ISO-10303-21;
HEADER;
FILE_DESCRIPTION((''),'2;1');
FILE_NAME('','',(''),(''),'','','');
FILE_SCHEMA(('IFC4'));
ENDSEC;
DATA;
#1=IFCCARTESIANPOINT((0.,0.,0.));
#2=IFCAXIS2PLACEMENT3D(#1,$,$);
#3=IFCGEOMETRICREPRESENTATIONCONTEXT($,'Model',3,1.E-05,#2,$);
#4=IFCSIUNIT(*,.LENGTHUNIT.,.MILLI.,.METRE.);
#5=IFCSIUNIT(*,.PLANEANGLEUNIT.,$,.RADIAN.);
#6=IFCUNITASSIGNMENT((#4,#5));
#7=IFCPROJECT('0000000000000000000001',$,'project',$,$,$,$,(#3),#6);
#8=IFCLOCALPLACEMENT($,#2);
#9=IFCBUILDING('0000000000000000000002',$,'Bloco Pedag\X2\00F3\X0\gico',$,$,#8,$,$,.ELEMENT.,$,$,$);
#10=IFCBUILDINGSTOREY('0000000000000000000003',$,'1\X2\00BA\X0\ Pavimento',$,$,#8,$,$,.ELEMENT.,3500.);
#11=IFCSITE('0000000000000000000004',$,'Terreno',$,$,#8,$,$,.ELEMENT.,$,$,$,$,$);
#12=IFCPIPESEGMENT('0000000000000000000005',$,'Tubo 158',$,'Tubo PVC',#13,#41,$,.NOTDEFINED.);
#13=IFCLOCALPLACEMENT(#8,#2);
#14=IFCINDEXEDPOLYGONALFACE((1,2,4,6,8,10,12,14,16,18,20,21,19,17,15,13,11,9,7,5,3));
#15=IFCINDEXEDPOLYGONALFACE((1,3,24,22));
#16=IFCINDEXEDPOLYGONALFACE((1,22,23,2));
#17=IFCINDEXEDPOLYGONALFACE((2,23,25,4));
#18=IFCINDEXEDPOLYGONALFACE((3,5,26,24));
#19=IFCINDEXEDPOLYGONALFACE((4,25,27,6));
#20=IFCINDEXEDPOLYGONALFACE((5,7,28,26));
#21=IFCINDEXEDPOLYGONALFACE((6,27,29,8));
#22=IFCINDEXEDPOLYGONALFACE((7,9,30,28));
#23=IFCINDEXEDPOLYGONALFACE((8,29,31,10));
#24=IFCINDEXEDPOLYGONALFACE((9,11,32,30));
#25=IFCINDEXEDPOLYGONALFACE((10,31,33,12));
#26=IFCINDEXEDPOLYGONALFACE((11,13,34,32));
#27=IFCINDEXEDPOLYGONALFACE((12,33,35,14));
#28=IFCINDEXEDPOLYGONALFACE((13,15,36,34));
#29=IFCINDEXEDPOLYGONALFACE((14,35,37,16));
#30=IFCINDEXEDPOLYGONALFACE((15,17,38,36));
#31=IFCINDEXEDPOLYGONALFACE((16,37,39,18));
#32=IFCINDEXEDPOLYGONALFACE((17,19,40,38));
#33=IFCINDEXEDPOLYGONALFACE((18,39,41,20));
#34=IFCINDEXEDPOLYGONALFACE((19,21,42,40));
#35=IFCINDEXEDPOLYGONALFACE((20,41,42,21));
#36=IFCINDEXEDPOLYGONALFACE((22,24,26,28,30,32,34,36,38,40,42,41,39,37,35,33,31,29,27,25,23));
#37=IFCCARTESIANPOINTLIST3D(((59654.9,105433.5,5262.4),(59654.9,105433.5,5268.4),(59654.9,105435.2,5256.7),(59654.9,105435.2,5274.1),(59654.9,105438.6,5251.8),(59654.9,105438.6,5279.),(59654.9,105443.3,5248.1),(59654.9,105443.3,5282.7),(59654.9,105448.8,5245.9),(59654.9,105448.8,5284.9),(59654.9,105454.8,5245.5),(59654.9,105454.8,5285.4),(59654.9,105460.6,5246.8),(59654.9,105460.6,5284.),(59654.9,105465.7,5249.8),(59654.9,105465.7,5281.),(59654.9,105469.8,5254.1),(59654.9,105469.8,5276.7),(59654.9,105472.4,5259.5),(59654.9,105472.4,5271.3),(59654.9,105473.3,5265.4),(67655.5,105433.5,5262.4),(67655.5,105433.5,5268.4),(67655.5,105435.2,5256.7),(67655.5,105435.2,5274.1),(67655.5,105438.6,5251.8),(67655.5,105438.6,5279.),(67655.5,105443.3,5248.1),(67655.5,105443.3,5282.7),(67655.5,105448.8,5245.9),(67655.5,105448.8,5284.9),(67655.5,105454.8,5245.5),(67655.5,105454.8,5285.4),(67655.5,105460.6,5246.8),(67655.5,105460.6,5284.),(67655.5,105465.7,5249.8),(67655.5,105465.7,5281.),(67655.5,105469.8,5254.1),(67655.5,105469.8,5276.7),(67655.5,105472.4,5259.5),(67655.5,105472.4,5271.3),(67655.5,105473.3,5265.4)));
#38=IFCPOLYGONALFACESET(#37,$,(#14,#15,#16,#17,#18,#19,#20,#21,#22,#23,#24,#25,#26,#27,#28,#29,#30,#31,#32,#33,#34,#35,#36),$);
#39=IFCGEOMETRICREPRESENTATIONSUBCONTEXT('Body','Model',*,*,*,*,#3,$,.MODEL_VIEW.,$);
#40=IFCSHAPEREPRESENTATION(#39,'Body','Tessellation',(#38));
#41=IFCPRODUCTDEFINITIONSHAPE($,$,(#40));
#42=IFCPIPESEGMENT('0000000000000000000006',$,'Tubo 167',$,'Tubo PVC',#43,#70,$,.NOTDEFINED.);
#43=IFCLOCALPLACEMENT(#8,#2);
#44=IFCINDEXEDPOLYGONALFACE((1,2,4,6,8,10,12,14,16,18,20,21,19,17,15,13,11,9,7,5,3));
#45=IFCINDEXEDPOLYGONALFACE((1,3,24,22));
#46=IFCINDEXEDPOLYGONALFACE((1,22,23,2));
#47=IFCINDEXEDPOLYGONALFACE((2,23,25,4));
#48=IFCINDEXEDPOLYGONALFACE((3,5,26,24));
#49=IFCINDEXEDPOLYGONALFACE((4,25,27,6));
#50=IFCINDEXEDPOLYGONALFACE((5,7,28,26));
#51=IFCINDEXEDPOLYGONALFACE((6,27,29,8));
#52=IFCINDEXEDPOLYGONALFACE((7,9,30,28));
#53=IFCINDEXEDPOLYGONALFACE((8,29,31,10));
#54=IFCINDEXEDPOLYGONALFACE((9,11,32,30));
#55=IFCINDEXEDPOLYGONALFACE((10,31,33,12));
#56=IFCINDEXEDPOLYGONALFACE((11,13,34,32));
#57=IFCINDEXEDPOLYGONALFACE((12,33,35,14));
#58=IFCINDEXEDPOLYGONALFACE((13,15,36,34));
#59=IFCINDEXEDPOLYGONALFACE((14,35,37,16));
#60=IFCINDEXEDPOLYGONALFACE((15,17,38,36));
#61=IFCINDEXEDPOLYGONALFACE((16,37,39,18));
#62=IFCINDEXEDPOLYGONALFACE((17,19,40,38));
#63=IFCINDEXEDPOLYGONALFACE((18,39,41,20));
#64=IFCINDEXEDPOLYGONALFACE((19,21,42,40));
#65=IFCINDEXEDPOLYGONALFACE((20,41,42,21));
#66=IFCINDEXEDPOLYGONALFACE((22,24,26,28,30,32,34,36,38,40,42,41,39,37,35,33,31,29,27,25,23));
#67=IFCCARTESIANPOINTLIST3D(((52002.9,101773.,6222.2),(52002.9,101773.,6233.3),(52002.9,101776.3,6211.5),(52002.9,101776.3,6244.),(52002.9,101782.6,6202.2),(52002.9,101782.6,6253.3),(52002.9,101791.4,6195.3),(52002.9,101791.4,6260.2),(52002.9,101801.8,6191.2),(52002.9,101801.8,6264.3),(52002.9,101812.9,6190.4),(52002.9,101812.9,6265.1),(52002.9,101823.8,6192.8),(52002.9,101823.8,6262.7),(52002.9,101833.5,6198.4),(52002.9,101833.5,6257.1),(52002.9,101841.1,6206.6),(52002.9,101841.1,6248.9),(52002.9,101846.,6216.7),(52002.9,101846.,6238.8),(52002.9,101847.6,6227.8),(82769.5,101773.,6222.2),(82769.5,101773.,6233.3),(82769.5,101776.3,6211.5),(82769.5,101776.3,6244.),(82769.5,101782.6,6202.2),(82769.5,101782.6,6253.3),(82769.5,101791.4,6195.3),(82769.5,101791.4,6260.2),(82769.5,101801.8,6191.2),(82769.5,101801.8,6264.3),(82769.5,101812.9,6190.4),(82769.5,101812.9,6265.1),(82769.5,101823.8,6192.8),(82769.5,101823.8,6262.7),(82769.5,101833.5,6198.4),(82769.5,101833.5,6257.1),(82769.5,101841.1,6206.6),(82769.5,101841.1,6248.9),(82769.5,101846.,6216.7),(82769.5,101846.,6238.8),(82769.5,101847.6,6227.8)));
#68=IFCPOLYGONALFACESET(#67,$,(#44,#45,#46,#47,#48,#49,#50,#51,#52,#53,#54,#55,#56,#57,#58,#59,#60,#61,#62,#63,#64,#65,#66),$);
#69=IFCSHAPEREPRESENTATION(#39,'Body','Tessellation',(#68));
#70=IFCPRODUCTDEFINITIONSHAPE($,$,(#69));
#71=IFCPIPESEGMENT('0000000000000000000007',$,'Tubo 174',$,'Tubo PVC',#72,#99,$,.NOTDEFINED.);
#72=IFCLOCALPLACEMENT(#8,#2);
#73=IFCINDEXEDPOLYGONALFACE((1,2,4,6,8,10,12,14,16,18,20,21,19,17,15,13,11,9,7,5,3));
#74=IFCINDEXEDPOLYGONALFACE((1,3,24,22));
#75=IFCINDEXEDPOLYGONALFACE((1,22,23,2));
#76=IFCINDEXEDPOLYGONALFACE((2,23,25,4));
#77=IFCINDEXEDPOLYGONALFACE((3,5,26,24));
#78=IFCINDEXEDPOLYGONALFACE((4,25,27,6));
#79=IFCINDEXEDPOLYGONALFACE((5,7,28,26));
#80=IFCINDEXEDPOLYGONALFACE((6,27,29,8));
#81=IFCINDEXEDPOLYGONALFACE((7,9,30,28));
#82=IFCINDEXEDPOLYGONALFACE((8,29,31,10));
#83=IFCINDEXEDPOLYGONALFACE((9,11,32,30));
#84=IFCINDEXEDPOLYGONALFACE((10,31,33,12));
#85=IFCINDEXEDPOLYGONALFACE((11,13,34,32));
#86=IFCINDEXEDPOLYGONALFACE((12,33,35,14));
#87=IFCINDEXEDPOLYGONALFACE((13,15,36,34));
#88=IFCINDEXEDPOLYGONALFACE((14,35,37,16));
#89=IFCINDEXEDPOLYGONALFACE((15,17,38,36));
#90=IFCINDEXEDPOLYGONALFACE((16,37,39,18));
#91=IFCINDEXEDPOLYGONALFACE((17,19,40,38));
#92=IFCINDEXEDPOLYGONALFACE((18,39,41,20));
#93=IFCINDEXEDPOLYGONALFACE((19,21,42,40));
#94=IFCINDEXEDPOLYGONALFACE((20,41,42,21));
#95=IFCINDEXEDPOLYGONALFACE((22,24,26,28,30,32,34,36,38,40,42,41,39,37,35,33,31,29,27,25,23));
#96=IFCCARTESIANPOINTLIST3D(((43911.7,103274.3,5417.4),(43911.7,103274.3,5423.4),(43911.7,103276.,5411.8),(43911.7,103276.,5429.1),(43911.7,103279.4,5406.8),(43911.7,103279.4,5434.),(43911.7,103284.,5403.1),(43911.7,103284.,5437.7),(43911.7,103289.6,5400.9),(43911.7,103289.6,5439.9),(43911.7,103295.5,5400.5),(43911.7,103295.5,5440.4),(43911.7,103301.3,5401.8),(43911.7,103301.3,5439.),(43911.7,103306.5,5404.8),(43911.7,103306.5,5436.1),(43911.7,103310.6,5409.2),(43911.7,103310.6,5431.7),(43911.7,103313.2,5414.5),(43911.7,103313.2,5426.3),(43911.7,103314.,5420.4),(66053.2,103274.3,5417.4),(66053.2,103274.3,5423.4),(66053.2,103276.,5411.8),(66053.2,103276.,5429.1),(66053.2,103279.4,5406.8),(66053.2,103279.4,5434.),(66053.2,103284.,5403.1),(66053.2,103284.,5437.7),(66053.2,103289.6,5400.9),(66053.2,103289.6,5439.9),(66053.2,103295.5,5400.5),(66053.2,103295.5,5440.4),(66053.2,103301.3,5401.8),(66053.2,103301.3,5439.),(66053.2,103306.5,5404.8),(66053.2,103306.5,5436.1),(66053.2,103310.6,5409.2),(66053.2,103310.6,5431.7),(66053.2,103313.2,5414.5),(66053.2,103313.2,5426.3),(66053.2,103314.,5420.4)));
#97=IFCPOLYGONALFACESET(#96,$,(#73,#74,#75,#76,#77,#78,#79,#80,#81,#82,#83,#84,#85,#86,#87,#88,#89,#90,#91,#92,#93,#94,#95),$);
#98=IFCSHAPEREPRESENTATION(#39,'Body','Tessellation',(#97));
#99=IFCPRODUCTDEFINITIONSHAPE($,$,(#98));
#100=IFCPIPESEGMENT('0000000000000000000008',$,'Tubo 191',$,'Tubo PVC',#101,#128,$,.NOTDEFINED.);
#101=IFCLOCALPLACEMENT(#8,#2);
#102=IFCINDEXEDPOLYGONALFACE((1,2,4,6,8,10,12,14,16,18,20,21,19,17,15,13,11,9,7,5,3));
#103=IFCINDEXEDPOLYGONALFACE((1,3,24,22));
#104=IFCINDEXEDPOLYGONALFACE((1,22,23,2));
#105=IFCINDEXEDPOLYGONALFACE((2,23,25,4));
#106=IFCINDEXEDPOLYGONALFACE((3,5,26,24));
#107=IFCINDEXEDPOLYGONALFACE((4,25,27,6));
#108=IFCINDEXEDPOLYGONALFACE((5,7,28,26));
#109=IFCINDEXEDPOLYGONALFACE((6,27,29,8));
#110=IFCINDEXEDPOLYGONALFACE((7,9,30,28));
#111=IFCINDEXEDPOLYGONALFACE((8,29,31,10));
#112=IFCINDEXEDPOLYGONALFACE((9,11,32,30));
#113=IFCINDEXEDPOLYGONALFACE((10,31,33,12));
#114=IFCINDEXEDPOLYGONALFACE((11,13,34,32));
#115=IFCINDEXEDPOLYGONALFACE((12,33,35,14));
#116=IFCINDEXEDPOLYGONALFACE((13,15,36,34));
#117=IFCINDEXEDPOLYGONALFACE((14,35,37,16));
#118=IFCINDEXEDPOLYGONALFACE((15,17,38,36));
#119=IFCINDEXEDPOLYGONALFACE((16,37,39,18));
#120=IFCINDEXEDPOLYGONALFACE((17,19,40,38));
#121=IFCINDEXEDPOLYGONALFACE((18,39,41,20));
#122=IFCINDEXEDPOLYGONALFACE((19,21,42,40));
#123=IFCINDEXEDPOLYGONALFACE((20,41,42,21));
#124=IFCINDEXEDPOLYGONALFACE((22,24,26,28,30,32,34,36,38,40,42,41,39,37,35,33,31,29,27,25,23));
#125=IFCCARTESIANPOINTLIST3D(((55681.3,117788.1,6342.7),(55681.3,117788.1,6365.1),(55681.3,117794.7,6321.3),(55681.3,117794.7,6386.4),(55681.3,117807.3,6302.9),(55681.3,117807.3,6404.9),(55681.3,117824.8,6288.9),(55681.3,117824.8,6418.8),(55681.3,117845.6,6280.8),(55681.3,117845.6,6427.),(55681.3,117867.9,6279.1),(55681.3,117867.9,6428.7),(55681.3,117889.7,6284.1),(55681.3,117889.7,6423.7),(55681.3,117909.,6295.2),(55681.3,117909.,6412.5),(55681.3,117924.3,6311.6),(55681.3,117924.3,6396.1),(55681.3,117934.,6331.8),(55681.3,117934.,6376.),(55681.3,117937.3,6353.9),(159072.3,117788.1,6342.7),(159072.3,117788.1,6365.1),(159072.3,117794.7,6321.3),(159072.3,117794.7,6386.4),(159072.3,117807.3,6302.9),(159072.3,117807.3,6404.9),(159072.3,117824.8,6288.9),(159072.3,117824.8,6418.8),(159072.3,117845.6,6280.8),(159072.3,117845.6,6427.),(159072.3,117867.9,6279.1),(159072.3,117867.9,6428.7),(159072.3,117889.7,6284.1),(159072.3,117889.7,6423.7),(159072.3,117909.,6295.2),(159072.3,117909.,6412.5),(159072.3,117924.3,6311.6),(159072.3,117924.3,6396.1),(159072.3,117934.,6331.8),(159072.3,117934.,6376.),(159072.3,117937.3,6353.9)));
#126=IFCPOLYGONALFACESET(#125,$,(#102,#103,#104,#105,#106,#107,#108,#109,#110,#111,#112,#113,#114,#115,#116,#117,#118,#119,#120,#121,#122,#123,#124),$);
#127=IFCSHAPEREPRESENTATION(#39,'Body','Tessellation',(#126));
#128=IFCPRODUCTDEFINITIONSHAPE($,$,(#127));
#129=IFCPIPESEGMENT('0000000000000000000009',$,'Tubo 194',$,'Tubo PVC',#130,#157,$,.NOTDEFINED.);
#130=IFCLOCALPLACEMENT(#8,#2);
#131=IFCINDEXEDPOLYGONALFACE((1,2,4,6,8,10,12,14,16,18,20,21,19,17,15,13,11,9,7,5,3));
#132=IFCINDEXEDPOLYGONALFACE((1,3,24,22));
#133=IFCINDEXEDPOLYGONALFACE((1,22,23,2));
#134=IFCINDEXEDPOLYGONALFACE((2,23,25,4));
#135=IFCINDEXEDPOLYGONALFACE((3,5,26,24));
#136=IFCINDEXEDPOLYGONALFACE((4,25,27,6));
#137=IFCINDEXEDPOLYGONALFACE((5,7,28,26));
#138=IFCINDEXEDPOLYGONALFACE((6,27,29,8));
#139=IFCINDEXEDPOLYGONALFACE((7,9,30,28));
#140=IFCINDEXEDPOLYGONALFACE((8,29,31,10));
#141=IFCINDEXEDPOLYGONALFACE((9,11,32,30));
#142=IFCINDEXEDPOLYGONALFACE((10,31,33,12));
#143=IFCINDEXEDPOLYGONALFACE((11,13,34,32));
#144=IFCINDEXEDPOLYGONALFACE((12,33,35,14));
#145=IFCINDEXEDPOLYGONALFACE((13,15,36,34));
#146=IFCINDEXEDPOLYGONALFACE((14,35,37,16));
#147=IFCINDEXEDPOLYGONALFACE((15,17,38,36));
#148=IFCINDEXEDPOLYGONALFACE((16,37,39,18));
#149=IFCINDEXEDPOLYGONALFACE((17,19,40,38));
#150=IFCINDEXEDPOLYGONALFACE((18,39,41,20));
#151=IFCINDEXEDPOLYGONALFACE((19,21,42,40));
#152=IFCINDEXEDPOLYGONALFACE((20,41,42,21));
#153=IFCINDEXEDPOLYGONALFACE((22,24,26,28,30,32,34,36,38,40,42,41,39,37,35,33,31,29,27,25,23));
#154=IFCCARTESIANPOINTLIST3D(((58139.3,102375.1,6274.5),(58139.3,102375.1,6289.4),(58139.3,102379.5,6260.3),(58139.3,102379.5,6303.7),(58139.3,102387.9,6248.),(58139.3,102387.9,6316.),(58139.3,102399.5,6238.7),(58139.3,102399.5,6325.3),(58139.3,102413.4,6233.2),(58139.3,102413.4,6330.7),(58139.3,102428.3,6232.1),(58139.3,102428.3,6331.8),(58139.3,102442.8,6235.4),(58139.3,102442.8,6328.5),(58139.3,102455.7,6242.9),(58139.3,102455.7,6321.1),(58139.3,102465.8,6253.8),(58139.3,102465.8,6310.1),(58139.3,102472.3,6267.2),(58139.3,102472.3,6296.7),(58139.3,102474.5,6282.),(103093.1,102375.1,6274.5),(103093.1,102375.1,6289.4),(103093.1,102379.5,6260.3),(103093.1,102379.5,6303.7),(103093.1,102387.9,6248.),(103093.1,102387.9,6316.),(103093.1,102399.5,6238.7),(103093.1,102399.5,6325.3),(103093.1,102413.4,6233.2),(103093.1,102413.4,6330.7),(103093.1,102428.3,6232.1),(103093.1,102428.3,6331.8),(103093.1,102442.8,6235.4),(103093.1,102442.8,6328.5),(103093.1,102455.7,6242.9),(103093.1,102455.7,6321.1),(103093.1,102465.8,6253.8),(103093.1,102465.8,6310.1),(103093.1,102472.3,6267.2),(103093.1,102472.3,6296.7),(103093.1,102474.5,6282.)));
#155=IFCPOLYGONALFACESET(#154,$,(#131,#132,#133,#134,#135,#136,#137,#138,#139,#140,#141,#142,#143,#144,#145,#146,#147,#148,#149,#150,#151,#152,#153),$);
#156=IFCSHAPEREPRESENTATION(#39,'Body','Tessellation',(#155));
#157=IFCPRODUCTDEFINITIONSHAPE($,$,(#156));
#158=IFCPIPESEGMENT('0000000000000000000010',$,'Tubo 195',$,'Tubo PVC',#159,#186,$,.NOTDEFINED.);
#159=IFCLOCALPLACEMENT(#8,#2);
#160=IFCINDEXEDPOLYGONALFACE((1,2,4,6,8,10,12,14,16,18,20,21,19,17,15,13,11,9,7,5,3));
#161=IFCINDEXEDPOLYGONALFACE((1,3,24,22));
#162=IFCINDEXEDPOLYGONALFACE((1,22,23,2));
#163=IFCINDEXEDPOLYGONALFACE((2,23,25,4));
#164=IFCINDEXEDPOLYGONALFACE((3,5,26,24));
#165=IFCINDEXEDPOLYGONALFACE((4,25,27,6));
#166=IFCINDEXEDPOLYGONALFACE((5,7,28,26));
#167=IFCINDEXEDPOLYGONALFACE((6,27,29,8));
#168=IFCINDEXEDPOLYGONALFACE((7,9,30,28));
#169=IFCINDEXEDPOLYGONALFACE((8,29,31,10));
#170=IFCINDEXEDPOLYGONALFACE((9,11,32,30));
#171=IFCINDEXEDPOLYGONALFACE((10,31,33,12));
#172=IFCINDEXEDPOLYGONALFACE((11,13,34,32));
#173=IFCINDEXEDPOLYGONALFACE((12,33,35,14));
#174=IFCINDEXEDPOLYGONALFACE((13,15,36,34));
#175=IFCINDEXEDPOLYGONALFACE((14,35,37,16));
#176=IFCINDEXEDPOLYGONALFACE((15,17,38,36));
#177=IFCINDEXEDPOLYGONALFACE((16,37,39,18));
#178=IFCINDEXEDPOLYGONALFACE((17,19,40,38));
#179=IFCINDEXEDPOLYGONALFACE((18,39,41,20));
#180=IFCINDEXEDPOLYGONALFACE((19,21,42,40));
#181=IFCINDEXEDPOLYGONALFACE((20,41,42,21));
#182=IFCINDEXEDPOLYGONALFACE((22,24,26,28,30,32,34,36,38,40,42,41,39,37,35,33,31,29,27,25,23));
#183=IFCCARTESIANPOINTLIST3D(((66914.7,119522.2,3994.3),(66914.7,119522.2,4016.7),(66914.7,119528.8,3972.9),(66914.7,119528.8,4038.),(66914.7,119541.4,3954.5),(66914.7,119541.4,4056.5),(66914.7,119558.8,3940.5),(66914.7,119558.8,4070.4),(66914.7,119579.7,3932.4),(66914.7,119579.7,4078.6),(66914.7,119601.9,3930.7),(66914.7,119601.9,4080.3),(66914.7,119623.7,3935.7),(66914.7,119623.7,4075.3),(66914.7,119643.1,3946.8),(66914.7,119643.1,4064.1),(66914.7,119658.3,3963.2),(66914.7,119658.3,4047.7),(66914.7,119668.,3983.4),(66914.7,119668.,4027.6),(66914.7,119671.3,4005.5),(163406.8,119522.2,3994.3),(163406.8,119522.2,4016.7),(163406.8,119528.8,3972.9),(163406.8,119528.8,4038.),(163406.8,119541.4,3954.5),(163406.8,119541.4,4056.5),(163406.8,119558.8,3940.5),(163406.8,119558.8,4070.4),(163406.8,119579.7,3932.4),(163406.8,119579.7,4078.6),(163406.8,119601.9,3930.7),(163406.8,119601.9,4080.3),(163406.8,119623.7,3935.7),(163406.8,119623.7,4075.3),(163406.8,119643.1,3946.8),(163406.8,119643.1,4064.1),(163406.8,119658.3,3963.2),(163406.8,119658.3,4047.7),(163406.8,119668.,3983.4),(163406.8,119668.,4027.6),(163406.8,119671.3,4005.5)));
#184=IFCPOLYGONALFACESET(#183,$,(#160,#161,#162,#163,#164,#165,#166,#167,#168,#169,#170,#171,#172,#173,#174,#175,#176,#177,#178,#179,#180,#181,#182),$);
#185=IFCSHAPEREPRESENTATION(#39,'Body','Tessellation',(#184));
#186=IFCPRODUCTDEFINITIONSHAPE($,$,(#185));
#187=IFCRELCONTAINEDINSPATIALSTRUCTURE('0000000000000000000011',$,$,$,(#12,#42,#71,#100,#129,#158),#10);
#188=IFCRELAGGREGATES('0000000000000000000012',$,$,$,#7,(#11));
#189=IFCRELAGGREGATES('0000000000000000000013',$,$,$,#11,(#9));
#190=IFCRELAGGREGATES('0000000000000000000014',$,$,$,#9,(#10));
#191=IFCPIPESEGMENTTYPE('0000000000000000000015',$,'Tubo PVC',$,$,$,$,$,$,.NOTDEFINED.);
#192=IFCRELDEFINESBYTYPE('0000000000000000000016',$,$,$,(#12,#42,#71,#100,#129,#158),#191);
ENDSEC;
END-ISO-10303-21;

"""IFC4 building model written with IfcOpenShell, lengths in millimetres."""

from ifc_helpers import new_model, si_unit, frame, origin, origin_2d, place, context, subcontext, project, spatial, circle, extrude, type_object, element, save


model = new_model("IFC4")

# Units and contexts
model_context = context("Model", 3, precision=1e-05, world=origin())
body_context = subcontext(model_context, "Body", "Model", "MODEL_VIEW")
ifc_project = project(units=[si_unit("LENGTHUNIT", "METRE", prefix="MILLI"), si_unit("PLANEANGLEUNIT", "RADIAN")], contexts=[model_context])

# Site, building, storey
placement = place(None, origin())
site = spatial("IfcSite", under=ifc_project, at=placement, Name="Terreno", CompositionType="ELEMENT")
building = spatial("IfcBuilding", under=site, at=placement, Name="Bloco Pedagógico", CompositionType="ELEMENT")
storey = spatial("IfcBuildingStorey", under=building, at=placement, Name="1º Pavimento", CompositionType="ELEMENT", Elevation=3500.0)

# Pipe segments
pipe_segment_type = type_object("IfcPipeSegmentType", Name="Tubo PVC", PredefinedType="NOTDEFINED")
pipe_segment_1_placement = place(None, frame((59654.9, 105453.3, 5265.4), z_axis=(1.0, 0.0, 0.0), x_axis=(0.0, 1.0, 0.0)))
element("IfcPipeSegment", 1, at=pipe_segment_1_placement, inside=storey, type_object=pipe_segment_type, Name="Tubo 158", ObjectType="Tubo PVC", PredefinedType="NOTDEFINED", context=body_context, shape_type="SweptSolid", body=[
    extrude(circle(Radius=20.0, at=origin_2d()), None, (0.0, 0.0, 1.0), 8000.7),
])
pipe_segment_2_placement = place(None, frame((52002.9, 101810.1, 6227.8), z_axis=(1.0, 0.0, 0.0), x_axis=(0.0, 1.0, 0.0)))
element("IfcPipeSegment", 2, at=pipe_segment_2_placement, inside=storey, type_object=pipe_segment_type, Name="Tubo 167", ObjectType="Tubo PVC", PredefinedType="NOTDEFINED", context=body_context, shape_type="SweptSolid", body=[
    extrude(circle(Radius=37.5, at=origin_2d()), None, (0.0, 0.0, 1.0), 30766.6),
])
pipe_segment_3_placement = place(None, frame((43911.7, 103294.0, 5420.4), z_axis=(1.0, 0.0, 0.0), x_axis=(0.0, 1.0, 0.0)))
element("IfcPipeSegment", 3, at=pipe_segment_3_placement, inside=storey, type_object=pipe_segment_type, Name="Tubo 174", ObjectType="Tubo PVC", PredefinedType="NOTDEFINED", context=body_context, shape_type="SweptSolid", body=[
    extrude(circle(Radius=20.0, at=origin_2d()), None, (0.0, 0.0, 1.0), 22141.5),
])
pipe_segment_4_placement = place(None, frame((55681.3, 117862.3, 6353.9), z_axis=(1.0, 0.0, 0.0), x_axis=(0.0, 1.0, 0.0)))
element("IfcPipeSegment", 4, at=pipe_segment_4_placement, inside=storey, type_object=pipe_segment_type, Name="Tubo 191", ObjectType="Tubo PVC", PredefinedType="NOTDEFINED", context=body_context, shape_type="SweptSolid", body=[
    extrude(circle(Radius=75.0, at=origin_2d()), None, (0.0, 0.0, 1.0), 103391.0),
])
pipe_segment_5_placement = place(None, frame((58139.3, 102424.5, 6282.0), z_axis=(1.0, 0.0, 0.0), x_axis=(0.0, 1.0, 0.0)))
element("IfcPipeSegment", 5, at=pipe_segment_5_placement, inside=storey, type_object=pipe_segment_type, Name="Tubo 194", ObjectType="Tubo PVC", PredefinedType="NOTDEFINED", context=body_context, shape_type="SweptSolid", body=[
    extrude(circle(Radius=50.0, at=origin_2d()), None, (0.0, 0.0, 1.0), 44953.8),
])
pipe_segment_6_placement = place(None, frame((66914.7, 119596.3, 4005.5), z_axis=(1.0, 0.0, 0.0), x_axis=(0.0, 1.0, 0.0)))
element("IfcPipeSegment", 6, at=pipe_segment_6_placement, inside=storey, type_object=pipe_segment_type, Name="Tubo 195", ObjectType="Tubo PVC", PredefinedType="NOTDEFINED", context=body_context, shape_type="SweptSolid", body=[
    extrude(circle(Radius=75.0, at=origin_2d()), None, (0.0, 0.0, 1.0), 96492.1),
])

save(model, "model.ifc")
